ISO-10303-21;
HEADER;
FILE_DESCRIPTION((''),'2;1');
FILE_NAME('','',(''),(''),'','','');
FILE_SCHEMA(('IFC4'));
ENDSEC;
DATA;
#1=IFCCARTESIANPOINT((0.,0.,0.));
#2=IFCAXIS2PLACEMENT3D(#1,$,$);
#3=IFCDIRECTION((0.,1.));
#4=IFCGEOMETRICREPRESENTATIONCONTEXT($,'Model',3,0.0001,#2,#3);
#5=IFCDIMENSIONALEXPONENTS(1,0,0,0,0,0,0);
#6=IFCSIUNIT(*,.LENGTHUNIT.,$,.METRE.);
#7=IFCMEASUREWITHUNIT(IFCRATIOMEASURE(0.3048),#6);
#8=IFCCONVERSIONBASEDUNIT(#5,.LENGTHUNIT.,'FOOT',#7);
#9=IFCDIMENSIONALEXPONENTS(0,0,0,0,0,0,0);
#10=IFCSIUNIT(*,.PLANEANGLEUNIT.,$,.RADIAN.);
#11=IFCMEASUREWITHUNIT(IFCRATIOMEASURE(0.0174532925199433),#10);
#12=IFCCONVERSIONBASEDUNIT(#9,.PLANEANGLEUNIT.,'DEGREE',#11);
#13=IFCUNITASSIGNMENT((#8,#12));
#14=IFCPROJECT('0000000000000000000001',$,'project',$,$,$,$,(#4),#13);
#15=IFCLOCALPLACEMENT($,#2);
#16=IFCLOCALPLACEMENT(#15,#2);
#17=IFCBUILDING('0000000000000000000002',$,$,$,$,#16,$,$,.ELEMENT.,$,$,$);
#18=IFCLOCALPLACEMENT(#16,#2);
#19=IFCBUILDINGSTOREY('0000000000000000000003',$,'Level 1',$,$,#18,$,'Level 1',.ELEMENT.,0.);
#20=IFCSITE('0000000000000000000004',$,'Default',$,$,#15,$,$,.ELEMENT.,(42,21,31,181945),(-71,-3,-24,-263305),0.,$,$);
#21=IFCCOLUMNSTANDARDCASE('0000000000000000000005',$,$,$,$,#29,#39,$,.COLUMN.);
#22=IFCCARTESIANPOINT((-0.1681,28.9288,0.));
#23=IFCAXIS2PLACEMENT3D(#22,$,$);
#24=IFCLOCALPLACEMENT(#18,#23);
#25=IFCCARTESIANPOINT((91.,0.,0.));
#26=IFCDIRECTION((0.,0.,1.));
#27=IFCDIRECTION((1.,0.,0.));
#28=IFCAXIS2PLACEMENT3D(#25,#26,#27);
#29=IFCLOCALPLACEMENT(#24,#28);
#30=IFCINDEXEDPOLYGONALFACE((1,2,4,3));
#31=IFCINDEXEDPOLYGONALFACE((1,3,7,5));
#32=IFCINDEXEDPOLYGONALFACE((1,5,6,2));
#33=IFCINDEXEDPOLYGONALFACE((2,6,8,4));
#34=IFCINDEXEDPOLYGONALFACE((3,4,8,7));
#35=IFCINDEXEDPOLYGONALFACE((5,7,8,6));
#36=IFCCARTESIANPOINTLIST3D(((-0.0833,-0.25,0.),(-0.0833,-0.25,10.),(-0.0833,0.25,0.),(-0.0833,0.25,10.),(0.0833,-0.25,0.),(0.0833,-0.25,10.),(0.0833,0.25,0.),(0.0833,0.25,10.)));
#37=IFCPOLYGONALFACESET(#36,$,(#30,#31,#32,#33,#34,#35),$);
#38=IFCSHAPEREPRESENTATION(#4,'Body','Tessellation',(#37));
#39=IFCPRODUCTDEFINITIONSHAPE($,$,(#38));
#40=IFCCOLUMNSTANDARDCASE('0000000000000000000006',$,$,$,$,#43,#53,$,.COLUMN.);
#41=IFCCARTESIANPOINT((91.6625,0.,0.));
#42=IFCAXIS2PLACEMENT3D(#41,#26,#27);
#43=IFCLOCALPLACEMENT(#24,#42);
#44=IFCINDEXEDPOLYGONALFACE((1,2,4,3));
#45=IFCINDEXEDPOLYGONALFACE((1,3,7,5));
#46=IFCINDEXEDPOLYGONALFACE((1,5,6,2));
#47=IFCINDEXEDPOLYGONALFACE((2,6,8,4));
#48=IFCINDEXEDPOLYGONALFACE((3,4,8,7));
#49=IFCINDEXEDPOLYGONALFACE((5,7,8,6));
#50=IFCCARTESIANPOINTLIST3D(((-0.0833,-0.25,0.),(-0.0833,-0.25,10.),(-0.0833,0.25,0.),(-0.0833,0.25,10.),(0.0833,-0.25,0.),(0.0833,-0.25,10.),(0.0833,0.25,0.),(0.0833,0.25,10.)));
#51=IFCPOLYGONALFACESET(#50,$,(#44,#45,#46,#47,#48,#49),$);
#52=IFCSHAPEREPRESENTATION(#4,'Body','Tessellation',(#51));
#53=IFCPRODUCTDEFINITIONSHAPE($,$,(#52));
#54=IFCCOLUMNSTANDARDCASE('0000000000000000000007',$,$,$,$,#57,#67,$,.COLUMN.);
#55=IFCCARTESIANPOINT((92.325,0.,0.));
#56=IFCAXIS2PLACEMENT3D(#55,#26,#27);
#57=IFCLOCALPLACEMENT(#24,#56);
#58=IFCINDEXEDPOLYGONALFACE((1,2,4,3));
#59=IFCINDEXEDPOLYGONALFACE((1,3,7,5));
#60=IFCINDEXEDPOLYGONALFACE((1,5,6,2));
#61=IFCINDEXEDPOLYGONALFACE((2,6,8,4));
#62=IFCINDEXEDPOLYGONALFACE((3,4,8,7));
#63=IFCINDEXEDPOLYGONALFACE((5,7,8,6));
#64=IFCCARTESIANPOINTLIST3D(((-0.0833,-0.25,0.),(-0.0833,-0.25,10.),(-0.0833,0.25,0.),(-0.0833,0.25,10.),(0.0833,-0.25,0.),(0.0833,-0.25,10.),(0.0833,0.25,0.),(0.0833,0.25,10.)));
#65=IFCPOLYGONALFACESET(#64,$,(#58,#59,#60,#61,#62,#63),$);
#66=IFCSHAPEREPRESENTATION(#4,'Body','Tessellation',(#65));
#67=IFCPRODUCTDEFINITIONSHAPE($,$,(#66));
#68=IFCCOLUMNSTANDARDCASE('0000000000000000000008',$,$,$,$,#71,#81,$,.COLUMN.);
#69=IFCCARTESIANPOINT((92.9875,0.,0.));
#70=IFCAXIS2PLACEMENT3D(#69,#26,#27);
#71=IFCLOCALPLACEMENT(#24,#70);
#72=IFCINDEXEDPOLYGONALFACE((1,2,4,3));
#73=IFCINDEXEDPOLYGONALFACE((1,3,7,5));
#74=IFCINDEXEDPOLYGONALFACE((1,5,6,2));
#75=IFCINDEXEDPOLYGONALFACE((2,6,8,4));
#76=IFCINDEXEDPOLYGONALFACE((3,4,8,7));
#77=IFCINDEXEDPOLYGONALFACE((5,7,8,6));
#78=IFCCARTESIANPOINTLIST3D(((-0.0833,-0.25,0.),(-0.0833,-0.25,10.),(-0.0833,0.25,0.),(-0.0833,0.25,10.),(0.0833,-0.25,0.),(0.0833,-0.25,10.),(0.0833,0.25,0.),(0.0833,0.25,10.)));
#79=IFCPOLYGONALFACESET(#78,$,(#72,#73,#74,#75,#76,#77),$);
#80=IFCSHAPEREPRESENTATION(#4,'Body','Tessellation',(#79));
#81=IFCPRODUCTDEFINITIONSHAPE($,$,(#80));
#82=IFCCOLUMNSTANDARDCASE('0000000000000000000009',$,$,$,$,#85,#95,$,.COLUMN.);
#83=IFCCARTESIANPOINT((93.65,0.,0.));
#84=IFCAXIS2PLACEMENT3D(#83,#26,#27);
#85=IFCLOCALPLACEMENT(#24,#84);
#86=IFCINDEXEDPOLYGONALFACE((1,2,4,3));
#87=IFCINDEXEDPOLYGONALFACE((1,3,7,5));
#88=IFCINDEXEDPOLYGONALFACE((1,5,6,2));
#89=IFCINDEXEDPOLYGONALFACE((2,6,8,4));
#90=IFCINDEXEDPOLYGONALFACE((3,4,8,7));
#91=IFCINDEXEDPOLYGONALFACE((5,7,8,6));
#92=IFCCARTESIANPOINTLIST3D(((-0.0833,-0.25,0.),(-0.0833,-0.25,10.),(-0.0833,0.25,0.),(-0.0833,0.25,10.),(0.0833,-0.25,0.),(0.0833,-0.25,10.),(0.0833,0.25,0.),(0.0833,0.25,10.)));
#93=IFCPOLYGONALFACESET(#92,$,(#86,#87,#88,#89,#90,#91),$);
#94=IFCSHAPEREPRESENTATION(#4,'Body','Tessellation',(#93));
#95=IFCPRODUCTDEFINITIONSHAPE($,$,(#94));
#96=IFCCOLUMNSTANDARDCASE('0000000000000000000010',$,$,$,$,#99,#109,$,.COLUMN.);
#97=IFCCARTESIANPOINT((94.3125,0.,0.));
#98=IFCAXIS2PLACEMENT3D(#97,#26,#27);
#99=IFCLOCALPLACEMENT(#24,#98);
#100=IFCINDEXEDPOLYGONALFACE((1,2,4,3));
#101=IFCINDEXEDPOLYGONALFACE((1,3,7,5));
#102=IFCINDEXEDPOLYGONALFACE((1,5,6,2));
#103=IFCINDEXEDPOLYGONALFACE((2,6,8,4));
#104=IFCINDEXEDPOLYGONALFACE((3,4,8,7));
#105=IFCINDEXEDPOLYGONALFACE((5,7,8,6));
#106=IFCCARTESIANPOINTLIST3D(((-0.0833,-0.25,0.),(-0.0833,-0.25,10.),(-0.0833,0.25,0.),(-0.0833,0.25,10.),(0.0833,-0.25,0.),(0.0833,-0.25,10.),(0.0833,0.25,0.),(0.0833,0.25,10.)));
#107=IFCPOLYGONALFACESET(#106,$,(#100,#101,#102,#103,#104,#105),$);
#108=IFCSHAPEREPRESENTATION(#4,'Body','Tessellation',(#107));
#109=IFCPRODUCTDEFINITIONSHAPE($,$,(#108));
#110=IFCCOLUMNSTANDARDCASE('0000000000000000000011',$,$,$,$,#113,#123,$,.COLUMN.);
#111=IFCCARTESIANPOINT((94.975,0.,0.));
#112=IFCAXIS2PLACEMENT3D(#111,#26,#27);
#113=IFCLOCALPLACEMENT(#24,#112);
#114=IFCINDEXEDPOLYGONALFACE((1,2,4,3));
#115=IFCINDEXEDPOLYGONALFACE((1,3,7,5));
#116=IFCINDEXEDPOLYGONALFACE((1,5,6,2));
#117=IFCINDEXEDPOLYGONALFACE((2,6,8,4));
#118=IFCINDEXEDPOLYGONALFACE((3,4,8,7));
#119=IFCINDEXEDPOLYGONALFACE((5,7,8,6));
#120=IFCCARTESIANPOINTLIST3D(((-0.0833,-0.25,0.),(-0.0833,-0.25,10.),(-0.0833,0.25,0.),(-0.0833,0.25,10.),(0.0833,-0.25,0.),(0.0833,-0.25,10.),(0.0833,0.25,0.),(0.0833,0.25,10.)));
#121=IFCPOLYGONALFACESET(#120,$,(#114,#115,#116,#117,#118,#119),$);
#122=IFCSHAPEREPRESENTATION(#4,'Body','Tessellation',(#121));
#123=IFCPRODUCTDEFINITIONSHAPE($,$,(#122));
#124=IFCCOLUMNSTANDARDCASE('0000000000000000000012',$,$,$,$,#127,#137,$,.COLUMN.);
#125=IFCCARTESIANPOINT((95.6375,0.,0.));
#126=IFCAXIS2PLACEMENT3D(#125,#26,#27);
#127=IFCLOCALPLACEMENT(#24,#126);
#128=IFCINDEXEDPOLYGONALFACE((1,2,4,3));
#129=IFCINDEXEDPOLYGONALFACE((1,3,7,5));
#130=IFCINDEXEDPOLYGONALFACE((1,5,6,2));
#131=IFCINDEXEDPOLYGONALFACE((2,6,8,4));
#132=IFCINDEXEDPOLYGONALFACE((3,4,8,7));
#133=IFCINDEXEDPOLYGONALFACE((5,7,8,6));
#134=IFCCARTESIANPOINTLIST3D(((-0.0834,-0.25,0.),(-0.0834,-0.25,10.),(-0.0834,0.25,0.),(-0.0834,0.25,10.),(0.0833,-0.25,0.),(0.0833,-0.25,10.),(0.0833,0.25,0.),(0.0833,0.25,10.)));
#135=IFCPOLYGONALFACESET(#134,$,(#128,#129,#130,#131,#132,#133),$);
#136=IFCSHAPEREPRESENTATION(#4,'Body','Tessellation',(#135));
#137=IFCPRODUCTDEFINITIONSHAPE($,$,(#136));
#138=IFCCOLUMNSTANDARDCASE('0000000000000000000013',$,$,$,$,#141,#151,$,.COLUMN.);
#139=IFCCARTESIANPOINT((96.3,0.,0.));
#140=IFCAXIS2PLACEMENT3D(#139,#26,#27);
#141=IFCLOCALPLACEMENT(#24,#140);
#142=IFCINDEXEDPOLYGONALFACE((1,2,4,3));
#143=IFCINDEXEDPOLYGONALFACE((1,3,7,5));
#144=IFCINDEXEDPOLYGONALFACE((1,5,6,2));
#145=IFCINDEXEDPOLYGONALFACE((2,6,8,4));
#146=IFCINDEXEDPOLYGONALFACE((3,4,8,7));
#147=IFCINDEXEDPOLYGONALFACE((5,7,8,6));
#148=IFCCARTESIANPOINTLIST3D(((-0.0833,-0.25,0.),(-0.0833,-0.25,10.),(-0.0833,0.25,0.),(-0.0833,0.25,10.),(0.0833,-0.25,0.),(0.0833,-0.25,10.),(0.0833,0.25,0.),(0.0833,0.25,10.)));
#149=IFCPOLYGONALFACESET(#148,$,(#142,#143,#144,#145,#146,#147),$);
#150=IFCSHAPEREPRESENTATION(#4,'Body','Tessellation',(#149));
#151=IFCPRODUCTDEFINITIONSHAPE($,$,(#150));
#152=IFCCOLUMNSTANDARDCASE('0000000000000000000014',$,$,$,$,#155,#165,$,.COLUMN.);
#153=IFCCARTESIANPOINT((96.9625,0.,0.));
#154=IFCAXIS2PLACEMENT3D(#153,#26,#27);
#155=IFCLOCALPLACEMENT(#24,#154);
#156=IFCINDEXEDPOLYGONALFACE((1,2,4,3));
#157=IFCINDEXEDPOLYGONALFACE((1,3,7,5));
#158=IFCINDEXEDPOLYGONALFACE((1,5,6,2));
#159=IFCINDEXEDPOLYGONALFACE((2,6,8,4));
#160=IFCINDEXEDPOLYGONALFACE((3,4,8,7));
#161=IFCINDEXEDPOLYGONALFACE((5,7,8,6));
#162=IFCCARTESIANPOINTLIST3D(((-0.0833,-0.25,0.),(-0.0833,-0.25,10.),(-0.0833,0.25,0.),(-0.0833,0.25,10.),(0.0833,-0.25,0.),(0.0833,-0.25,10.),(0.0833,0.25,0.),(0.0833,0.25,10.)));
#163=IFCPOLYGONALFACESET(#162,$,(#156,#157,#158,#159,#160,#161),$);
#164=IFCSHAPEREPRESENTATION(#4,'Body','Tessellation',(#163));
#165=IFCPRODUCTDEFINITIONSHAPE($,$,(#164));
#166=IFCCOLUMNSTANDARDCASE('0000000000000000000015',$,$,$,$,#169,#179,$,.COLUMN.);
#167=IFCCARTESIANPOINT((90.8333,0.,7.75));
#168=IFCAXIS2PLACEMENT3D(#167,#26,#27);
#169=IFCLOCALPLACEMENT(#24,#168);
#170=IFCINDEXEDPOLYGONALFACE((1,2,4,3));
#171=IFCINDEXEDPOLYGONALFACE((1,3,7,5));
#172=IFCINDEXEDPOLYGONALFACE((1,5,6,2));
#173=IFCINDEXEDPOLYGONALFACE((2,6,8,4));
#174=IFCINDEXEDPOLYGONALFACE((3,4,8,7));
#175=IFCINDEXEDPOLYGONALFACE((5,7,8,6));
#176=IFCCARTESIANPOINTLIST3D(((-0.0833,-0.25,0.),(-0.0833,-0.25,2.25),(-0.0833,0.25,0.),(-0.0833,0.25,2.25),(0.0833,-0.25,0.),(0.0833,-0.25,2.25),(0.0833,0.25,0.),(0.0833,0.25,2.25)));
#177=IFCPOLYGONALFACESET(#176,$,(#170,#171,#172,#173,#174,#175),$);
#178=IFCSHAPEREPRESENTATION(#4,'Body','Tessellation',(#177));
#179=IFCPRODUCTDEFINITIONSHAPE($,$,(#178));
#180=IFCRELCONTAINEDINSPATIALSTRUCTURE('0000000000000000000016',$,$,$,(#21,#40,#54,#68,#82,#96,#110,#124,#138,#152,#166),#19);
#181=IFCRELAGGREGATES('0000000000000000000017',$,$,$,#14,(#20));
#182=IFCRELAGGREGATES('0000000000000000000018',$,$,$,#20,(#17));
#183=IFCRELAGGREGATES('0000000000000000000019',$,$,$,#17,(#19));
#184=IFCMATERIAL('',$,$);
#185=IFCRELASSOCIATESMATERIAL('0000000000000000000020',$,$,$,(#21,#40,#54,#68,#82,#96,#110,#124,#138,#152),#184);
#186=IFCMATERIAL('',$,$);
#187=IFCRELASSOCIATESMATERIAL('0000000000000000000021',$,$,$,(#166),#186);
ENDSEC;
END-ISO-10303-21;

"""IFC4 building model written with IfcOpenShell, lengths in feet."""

from ifc_helpers import new_model, entity, si_unit, converted_unit, direction, frame, origin, place, context, project, spatial, rectangle, extrude, material, element, save


model = new_model("IFC4")

# Units and contexts
model_context = context("Model", 3, precision=0.0001, world=origin(), true_north=direction((0.0, 1.0)))
ifc_project = project(units=[converted_unit("LENGTHUNIT", "FOOT", entity("IfcRatioMeasure", 0.3048), si_unit("LENGTHUNIT", "METRE"), dimensions=[1, 0, 0, 0, 0, 0, 0]), converted_unit("PLANEANGLEUNIT", "DEGREE", entity("IfcRatioMeasure", 0.0174532925199433), si_unit("PLANEANGLEUNIT", "RADIAN"), dimensions=[0, 0, 0, 0, 0, 0, 0])], contexts=[model_context])

# Site, building, storey
site_placement = place(None, origin())
site = spatial("IfcSite", under=ifc_project, at=site_placement, Name="Default", CompositionType="ELEMENT", RefLatitude=(42, 21, 31, 181945), RefLongitude=(-71, -3, -24, -263305), RefElevation=0.0)
building_placement = place(site_placement, origin())
building = spatial("IfcBuilding", under=site, at=building_placement, CompositionType="ELEMENT")
storey_placement = place(building_placement, origin())
storey = spatial("IfcBuildingStorey", under=building, at=storey_placement, Name="Level 1", LongName="Level 1", CompositionType="ELEMENT", Elevation=0.0)

# Columns
ifc_material_1 = material(Name="")
placement = place(storey_placement, frame((-0.1681, 28.9288, 0.0)))
for number, where, z_axis, x_axis in (
    (1, (91.0, 0.0, 0.0), (0.0, 0.0, 1.0), (1.0, 0.0, 0.0)),
    (2, (91.6625, 0.0, 0.0), (0.0, 0.0, 1.0), (1.0, 0.0, 0.0)),
    (3, (92.325, 0.0, 0.0), (0.0, 0.0, 1.0), (1.0, 0.0, 0.0)),
    (4, (92.9875, 0.0, 0.0), (0.0, 0.0, 1.0), (1.0, 0.0, 0.0)),
    (5, (93.65, 0.0, 0.0), (0.0, 0.0, 1.0), (1.0, 0.0, 0.0)),
    (6, (94.3125, 0.0, 0.0), (0.0, 0.0, 1.0), (1.0, 0.0, 0.0)),
    (7, (94.975, 0.0, 0.0), (0.0, 0.0, 1.0), (1.0, 0.0, 0.0)),
    (8, (95.6375, 0.0, 0.0), (0.0, 0.0, 1.0), (1.0, 0.0, 0.0)),
    (9, (96.3, 0.0, 0.0), (0.0, 0.0, 1.0), (1.0, 0.0, 0.0)),
    (10, (96.9625, 0.0, 0.0), (0.0, 0.0, 1.0), (1.0, 0.0, 0.0)),
):
    element("IfcColumnStandardCase", number, at=place(placement, frame(where, z_axis=z_axis, x_axis=x_axis)), inside=storey, material=ifc_material_1, PredefinedType="COLUMN", context=model_context, shape_type="SweptSolid", body=[
        extrude(rectangle(XDim=0.1667, YDim=0.5), origin(), (0.0, 0.0, 1.0), 10.0),
    ])
ifc_material_2 = material(Name="")
for number, where, z_axis, x_axis in (
    (11, (90.8333, 0.0, 7.75), (0.0, 0.0, 1.0), (1.0, 0.0, 0.0)),
):
    element("IfcColumnStandardCase", number, at=place(placement, frame(where, z_axis=z_axis, x_axis=x_axis)), inside=storey, material=ifc_material_2, PredefinedType="COLUMN", context=model_context, shape_type="SweptSolid", body=[
        extrude(rectangle(XDim=0.1667, YDim=0.5), origin(), (0.0, 0.0, 1.0), 2.25),
    ])

save(model, "model.ifc")
